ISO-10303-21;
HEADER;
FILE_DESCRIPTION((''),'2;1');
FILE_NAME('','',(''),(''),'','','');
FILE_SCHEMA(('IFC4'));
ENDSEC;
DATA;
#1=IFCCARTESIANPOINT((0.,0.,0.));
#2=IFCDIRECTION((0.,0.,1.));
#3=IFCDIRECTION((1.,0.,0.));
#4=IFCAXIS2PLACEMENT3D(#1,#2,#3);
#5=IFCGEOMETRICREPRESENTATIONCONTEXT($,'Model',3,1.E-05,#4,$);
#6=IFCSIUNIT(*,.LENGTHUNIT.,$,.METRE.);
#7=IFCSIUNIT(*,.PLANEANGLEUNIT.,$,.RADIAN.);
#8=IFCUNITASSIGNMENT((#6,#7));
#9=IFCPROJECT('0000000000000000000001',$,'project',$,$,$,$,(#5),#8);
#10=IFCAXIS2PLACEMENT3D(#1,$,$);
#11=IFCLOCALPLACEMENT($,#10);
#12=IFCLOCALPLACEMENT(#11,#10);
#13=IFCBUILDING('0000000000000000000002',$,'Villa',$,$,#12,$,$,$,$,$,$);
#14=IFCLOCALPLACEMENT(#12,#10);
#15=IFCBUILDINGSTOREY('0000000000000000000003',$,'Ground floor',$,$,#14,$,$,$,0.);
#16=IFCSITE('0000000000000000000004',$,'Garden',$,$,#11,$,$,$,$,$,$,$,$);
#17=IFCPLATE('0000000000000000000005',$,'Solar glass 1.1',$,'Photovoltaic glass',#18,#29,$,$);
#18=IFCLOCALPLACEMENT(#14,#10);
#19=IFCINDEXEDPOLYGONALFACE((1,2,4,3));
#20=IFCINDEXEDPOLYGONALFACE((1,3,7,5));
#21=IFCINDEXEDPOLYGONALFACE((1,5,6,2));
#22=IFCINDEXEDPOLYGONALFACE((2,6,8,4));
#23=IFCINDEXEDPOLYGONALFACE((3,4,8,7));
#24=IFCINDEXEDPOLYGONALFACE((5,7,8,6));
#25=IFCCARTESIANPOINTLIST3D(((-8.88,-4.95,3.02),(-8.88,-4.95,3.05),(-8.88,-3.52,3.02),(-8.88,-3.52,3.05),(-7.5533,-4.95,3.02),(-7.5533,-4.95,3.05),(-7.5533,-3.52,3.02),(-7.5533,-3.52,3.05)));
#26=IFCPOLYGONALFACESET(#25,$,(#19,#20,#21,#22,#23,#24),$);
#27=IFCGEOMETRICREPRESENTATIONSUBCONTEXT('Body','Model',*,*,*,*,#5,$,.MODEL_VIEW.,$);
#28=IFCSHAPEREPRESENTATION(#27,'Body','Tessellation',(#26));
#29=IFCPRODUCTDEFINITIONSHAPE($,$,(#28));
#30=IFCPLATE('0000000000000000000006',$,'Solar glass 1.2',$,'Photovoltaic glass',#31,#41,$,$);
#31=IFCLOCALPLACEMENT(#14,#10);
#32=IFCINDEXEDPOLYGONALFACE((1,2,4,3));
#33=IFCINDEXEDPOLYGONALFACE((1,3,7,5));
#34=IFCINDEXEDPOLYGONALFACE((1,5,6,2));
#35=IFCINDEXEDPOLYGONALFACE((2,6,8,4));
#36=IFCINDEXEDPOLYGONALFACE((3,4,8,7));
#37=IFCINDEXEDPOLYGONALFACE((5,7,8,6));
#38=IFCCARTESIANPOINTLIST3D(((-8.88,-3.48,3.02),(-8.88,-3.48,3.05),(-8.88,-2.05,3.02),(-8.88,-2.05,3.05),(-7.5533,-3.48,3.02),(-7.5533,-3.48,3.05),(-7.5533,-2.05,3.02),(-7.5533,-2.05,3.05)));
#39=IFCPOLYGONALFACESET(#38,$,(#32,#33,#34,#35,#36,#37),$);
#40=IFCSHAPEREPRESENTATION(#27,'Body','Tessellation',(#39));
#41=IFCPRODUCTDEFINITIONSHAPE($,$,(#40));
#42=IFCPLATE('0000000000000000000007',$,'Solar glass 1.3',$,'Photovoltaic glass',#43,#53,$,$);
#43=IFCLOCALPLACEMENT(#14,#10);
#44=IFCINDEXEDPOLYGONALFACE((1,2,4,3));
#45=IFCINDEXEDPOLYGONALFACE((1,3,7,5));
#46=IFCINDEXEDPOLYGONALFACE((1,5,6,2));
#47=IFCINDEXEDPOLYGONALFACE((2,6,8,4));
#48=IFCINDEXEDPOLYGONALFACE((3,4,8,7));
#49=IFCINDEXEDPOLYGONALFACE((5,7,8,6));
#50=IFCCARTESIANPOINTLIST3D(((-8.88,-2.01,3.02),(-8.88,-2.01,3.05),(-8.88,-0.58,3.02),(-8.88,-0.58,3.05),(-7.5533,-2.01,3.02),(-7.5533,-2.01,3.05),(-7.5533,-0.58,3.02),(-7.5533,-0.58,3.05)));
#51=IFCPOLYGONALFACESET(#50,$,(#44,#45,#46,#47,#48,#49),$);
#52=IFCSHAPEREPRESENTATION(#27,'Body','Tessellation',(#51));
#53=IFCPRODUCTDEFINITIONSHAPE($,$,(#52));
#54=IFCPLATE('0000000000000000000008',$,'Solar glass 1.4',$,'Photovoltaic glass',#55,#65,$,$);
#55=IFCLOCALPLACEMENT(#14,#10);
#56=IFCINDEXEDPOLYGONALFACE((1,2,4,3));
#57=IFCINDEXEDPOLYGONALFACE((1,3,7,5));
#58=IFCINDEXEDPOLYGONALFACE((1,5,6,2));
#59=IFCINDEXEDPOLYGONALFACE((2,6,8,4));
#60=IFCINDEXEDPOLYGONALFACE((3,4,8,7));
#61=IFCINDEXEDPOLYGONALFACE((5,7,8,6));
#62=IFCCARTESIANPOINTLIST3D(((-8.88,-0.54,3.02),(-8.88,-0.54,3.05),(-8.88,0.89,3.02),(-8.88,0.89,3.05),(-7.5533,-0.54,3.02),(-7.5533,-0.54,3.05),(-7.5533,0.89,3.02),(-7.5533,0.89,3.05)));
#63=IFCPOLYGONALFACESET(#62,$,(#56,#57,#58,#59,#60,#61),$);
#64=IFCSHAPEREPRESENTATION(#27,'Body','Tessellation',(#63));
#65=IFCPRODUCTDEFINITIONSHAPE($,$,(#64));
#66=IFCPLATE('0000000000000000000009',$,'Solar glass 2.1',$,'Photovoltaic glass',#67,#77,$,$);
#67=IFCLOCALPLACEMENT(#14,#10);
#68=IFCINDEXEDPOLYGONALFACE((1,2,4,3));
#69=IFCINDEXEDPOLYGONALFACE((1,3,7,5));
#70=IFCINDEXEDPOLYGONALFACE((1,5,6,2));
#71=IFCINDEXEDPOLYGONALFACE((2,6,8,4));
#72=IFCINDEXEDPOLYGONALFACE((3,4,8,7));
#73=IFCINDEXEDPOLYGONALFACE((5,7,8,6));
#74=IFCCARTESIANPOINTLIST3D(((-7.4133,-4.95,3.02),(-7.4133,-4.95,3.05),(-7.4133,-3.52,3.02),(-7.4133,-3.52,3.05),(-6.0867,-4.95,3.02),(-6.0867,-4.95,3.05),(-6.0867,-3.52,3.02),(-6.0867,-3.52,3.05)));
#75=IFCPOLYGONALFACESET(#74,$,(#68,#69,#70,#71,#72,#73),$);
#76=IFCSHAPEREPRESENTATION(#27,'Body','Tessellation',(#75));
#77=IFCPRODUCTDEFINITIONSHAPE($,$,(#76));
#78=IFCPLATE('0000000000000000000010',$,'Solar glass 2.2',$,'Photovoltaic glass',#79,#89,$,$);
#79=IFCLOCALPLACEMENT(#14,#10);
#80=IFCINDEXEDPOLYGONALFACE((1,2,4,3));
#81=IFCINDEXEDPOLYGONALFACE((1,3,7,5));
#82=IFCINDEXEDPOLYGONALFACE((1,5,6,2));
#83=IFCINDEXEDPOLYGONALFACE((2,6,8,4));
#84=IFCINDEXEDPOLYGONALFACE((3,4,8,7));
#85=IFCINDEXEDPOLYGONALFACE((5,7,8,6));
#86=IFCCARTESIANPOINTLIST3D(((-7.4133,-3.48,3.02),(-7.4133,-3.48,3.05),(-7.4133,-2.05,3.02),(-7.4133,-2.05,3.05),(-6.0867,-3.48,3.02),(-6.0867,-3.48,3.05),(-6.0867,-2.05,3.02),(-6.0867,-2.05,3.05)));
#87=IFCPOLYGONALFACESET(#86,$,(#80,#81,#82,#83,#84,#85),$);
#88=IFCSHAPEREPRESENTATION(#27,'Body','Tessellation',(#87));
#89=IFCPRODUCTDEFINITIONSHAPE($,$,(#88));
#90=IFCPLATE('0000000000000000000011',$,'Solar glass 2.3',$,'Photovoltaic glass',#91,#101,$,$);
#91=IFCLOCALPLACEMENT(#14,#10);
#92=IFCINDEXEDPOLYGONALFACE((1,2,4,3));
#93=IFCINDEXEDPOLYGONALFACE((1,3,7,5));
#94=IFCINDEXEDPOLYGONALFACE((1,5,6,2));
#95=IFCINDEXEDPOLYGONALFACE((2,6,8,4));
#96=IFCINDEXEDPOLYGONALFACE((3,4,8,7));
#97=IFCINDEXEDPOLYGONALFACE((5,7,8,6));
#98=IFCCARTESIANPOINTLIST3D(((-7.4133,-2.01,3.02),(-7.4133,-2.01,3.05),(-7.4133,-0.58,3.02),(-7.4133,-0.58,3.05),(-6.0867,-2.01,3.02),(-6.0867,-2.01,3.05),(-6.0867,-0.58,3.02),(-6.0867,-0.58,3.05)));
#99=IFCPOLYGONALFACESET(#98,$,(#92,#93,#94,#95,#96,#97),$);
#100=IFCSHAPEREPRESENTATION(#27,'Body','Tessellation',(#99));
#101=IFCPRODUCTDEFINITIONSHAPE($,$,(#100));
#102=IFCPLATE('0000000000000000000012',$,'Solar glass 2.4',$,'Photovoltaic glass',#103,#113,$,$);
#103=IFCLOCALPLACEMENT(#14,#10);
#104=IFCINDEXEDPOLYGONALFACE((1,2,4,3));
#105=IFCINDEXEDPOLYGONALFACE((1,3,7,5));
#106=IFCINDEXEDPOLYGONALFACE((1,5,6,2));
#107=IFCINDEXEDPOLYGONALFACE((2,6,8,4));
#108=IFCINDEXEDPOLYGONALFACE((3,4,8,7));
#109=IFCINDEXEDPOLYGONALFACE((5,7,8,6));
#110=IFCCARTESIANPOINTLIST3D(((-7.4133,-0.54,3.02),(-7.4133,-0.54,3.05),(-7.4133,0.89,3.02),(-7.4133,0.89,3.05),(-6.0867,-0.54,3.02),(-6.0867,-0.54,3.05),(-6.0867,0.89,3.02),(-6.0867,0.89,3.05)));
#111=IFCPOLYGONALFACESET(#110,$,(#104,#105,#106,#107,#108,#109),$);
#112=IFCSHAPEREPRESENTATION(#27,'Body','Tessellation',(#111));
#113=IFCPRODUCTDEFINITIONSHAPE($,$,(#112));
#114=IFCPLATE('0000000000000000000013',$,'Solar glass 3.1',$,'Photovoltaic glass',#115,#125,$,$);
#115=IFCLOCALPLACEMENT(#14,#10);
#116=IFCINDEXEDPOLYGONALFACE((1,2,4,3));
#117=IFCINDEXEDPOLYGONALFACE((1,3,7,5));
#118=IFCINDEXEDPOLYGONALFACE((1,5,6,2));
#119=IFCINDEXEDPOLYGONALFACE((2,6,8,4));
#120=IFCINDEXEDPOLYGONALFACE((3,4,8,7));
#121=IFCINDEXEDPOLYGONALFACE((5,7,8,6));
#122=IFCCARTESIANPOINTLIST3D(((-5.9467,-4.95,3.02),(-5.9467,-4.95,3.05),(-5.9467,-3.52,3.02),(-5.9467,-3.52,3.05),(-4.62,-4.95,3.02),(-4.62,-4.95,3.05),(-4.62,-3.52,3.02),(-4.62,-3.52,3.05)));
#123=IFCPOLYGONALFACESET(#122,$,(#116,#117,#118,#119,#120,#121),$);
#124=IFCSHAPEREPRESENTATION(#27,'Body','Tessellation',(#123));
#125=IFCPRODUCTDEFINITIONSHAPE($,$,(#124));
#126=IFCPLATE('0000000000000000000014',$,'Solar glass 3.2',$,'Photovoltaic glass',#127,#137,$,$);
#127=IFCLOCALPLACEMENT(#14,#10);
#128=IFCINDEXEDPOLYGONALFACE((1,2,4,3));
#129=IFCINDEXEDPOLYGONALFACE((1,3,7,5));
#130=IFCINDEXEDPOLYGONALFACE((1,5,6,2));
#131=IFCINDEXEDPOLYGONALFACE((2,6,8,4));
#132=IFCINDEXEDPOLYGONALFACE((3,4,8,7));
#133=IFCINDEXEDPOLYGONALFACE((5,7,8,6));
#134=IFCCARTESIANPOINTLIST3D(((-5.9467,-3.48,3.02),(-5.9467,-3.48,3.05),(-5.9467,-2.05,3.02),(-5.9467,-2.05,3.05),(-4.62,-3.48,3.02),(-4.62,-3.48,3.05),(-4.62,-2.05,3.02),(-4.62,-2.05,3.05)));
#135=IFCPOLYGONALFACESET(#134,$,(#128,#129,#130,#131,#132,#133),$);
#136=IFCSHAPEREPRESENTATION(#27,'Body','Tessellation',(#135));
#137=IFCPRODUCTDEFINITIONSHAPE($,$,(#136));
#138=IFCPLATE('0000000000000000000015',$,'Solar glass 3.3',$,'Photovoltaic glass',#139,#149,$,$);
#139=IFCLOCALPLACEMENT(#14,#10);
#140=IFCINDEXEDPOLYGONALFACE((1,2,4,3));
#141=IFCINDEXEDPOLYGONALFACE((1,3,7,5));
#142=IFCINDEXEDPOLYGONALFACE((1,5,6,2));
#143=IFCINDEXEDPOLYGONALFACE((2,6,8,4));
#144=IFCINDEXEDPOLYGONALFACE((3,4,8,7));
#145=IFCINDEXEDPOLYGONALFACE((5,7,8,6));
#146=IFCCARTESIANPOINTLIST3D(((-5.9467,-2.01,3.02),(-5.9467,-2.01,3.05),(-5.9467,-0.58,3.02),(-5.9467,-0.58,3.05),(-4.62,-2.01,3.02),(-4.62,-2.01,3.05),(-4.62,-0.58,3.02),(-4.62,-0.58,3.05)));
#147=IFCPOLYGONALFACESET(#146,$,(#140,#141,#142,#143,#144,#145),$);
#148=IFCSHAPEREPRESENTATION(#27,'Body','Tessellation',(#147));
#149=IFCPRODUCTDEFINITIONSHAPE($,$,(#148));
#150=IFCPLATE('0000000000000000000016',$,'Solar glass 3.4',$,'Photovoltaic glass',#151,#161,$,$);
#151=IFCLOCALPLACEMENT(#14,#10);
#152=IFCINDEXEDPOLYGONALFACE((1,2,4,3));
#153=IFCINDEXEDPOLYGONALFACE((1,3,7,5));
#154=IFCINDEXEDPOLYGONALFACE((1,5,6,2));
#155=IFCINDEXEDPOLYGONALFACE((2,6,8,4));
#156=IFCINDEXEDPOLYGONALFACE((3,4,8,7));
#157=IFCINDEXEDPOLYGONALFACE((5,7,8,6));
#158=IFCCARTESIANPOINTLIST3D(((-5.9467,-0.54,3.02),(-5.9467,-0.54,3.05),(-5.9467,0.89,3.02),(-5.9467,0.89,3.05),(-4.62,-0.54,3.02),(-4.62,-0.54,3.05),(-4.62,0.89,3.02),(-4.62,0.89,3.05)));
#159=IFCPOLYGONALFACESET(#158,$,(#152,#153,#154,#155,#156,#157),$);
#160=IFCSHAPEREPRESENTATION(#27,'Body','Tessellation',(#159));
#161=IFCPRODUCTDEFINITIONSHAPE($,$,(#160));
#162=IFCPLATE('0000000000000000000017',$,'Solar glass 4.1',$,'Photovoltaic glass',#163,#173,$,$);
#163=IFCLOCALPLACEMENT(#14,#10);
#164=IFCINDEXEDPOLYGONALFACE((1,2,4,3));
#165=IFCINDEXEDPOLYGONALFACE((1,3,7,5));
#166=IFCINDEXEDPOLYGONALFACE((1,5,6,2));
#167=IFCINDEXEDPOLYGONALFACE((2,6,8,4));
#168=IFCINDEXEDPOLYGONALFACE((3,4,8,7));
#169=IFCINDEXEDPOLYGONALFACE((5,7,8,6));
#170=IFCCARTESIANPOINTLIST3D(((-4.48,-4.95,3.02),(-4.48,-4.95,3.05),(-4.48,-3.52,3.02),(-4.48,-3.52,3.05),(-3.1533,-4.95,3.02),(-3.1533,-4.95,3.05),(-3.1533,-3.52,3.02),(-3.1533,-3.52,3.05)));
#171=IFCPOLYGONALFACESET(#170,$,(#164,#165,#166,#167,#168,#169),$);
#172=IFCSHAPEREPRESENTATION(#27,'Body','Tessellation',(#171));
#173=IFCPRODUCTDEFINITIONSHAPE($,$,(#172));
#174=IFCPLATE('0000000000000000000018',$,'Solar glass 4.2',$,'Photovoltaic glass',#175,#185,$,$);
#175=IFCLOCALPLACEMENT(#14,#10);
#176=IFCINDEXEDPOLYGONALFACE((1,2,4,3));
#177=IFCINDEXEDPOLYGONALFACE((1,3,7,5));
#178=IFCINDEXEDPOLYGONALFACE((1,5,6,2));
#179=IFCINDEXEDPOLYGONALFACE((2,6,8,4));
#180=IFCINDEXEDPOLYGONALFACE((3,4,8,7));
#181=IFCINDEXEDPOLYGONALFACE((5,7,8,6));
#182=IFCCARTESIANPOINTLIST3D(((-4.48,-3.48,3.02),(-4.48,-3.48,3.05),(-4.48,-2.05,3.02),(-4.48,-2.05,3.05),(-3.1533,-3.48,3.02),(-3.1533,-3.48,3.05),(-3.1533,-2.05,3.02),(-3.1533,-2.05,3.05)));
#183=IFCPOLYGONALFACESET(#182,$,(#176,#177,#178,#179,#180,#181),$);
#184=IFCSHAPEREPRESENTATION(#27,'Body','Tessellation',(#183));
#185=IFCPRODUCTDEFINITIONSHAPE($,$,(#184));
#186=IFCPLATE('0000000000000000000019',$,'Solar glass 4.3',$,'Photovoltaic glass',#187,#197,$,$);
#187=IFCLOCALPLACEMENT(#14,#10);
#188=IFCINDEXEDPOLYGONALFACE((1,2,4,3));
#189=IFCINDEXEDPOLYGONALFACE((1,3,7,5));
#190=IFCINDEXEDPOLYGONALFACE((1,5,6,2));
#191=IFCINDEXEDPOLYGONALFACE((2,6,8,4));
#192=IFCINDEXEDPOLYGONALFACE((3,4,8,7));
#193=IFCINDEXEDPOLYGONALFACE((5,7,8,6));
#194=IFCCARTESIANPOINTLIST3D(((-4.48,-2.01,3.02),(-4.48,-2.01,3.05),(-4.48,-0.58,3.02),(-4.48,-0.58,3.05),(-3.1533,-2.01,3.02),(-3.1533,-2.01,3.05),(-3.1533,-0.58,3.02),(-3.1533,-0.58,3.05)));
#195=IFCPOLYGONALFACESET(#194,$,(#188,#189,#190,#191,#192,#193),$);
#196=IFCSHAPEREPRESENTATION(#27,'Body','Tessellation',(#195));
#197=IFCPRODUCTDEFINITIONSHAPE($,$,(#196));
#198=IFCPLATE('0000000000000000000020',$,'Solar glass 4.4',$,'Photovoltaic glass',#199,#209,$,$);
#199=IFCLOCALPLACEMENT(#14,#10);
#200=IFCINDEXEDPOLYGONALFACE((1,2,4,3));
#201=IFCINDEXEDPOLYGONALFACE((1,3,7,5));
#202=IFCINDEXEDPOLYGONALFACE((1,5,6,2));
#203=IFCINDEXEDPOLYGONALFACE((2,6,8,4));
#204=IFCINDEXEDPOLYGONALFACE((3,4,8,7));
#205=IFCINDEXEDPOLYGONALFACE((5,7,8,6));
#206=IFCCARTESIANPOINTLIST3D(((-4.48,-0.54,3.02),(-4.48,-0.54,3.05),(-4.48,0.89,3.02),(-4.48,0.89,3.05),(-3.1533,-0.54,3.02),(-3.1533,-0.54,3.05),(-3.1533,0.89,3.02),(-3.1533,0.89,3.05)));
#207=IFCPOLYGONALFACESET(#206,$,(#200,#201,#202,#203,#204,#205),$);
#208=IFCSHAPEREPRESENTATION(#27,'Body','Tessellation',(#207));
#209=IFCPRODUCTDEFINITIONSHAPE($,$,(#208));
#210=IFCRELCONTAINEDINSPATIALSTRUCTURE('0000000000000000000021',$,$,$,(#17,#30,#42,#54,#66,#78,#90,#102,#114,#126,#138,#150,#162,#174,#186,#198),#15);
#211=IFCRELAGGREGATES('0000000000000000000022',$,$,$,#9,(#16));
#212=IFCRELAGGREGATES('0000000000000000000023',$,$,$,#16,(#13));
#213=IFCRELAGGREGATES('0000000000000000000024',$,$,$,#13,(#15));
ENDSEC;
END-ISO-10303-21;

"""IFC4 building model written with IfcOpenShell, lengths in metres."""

from ifc_helpers import new_model, si_unit, frame, frame_2d, origin, origin_with_axes, place, context, subcontext, project, spatial, rectangle, extrude, element, save


model = new_model("IFC4")

# Units and contexts
model_context = context("Model", 3, precision=1e-05, world=origin_with_axes())
body_context = subcontext(model_context, "Body", "Model", "MODEL_VIEW")
ifc_project = project(units=[si_unit("LENGTHUNIT", "METRE"), si_unit("PLANEANGLEUNIT", "RADIAN")], contexts=[model_context])

# Site, building, storey
site_placement = place(None, origin())
site = spatial("IfcSite", under=ifc_project, at=site_placement, Name="Garden")
building_placement = place(site_placement, origin())
building = spatial("IfcBuilding", under=site, at=building_placement, Name="Villa")
storey_placement = place(building_placement, origin())
storey = spatial("IfcBuildingStorey", under=building, at=storey_placement, Name="Ground floor", Elevation=0.0)

# Plates
plate_1_placement = place(storey_placement, origin())
element("IfcPlate", 1, at=plate_1_placement, inside=storey, Name="Solar glass 1.1", ObjectType="Photovoltaic glass", context=body_context, shape_type="SweptSolid", body=[
    extrude(rectangle(XDim=1.3267, YDim=1.43, at=frame_2d((0.6633, 0.715))), frame((-8.88, -4.95, 3.02)), (0.0, 0.0, 1.0), 0.03),
])
plate_2_placement = place(storey_placement, origin())
element("IfcPlate", 2, at=plate_2_placement, inside=storey, Name="Solar glass 1.2", ObjectType="Photovoltaic glass", context=body_context, shape_type="SweptSolid", body=[
    extrude(rectangle(XDim=1.3267, YDim=1.43, at=frame_2d((0.6633, 0.715))), frame((-8.88, -3.48, 3.02)), (0.0, 0.0, 1.0), 0.03),
])
plate_3_placement = place(storey_placement, origin())
element("IfcPlate", 3, at=plate_3_placement, inside=storey, Name="Solar glass 1.3", ObjectType="Photovoltaic glass", context=body_context, shape_type="SweptSolid", body=[
    extrude(rectangle(XDim=1.3267, YDim=1.43, at=frame_2d((0.6633, 0.715))), frame((-8.88, -2.01, 3.02)), (0.0, 0.0, 1.0), 0.03),
])
plate_4_placement = place(storey_placement, origin())
element("IfcPlate", 4, at=plate_4_placement, inside=storey, Name="Solar glass 1.4", ObjectType="Photovoltaic glass", context=body_context, shape_type="SweptSolid", body=[
    extrude(rectangle(XDim=1.3267, YDim=1.43, at=frame_2d((0.6633, 0.715))), frame((-8.88, -0.54, 3.02)), (0.0, 0.0, 1.0), 0.03),
])
plate_5_placement = place(storey_placement, origin())
element("IfcPlate", 5, at=plate_5_placement, inside=storey, Name="Solar glass 2.1", ObjectType="Photovoltaic glass", context=body_context, shape_type="SweptSolid", body=[
    extrude(rectangle(XDim=1.3267, YDim=1.43, at=frame_2d((0.6633, 0.715))), frame((-7.4133, -4.95, 3.02)), (0.0, 0.0, 1.0), 0.03),
])
plate_6_placement = place(storey_placement, origin())
element("IfcPlate", 6, at=plate_6_placement, inside=storey, Name="Solar glass 2.2", ObjectType="Photovoltaic glass", context=body_context, shape_type="SweptSolid", body=[
    extrude(rectangle(XDim=1.3267, YDim=1.43, at=frame_2d((0.6633, 0.715))), frame((-7.4133, -3.48, 3.02)), (0.0, 0.0, 1.0), 0.03),
])
plate_7_placement = place(storey_placement, origin())
element("IfcPlate", 7, at=plate_7_placement, inside=storey, Name="Solar glass 2.3", ObjectType="Photovoltaic glass", context=body_context, shape_type="SweptSolid", body=[
    extrude(rectangle(XDim=1.3267, YDim=1.43, at=frame_2d((0.6633, 0.715))), frame((-7.4133, -2.01, 3.02)), (0.0, 0.0, 1.0), 0.03),
])
plate_8_placement = place(storey_placement, origin())
element("IfcPlate", 8, at=plate_8_placement, inside=storey, Name="Solar glass 2.4", ObjectType="Photovoltaic glass", context=body_context, shape_type="SweptSolid", body=[
    extrude(rectangle(XDim=1.3267, YDim=1.43, at=frame_2d((0.6633, 0.715))), frame((-7.4133, -0.54, 3.02)), (0.0, 0.0, 1.0), 0.03),
])
plate_9_placement = place(storey_placement, origin())
element("IfcPlate", 9, at=plate_9_placement, inside=storey, Name="Solar glass 3.1", ObjectType="Photovoltaic glass", context=body_context, shape_type="SweptSolid", body=[
    extrude(rectangle(XDim=1.3267, YDim=1.43, at=frame_2d((0.6633, 0.715))), frame((-5.9467, -4.95, 3.02)), (0.0, 0.0, 1.0), 0.03),
])
plate_10_placement = place(storey_placement, origin())
element("IfcPlate", 10, at=plate_10_placement, inside=storey, Name="Solar glass 3.2", ObjectType="Photovoltaic glass", context=body_context, shape_type="SweptSolid", body=[
    extrude(rectangle(XDim=1.3267, YDim=1.43, at=frame_2d((0.6633, 0.715))), frame((-5.9467, -3.48, 3.02)), (0.0, 0.0, 1.0), 0.03),
])
plate_11_placement = place(storey_placement, origin())
element("IfcPlate", 11, at=plate_11_placement, inside=storey, Name="Solar glass 3.3", ObjectType="Photovoltaic glass", context=body_context, shape_type="SweptSolid", body=[
    extrude(rectangle(XDim=1.3267, YDim=1.43, at=frame_2d((0.6633, 0.715))), frame((-5.9467, -2.01, 3.02)), (0.0, 0.0, 1.0), 0.03),
])
plate_12_placement = place(storey_placement, origin())
element("IfcPlate", 12, at=plate_12_placement, inside=storey, Name="Solar glass 3.4", ObjectType="Photovoltaic glass", context=body_context, shape_type="SweptSolid", body=[
    extrude(rectangle(XDim=1.3267, YDim=1.43, at=frame_2d((0.6633, 0.715))), frame((-5.9467, -0.54, 3.02)), (0.0, 0.0, 1.0), 0.03),
])
plate_13_placement = place(storey_placement, origin())
element("IfcPlate", 13, at=plate_13_placement, inside=storey, Name="Solar glass 4.1", ObjectType="Photovoltaic glass", context=body_context, shape_type="SweptSolid", body=[
    extrude(rectangle(XDim=1.3267, YDim=1.43, at=frame_2d((0.6633, 0.715))), frame((-4.48, -4.95, 3.02)), (0.0, 0.0, 1.0), 0.03),
])
plate_14_placement = place(storey_placement, origin())
element("IfcPlate", 14, at=plate_14_placement, inside=storey, Name="Solar glass 4.2", ObjectType="Photovoltaic glass", context=body_context, shape_type="SweptSolid", body=[
    extrude(rectangle(XDim=1.3267, YDim=1.43, at=frame_2d((0.6633, 0.715))), frame((-4.48, -3.48, 3.02)), (0.0, 0.0, 1.0), 0.03),
])
plate_15_placement = place(storey_placement, origin())
element("IfcPlate", 15, at=plate_15_placement, inside=storey, Name="Solar glass 4.3", ObjectType="Photovoltaic glass", context=body_context, shape_type="SweptSolid", body=[
    extrude(rectangle(XDim=1.3267, YDim=1.43, at=frame_2d((0.6633, 0.715))), frame((-4.48, -2.01, 3.02)), (0.0, 0.0, 1.0), 0.03),
])
plate_16_placement = place(storey_placement, origin())
element("IfcPlate", 16, at=plate_16_placement, inside=storey, Name="Solar glass 4.4", ObjectType="Photovoltaic glass", context=body_context, shape_type="SweptSolid", body=[
    extrude(rectangle(XDim=1.3267, YDim=1.43, at=frame_2d((0.6633, 0.715))), frame((-4.48, -0.54, 3.02)), (0.0, 0.0, 1.0), 0.03),
])

save(model, "model.ifc")
